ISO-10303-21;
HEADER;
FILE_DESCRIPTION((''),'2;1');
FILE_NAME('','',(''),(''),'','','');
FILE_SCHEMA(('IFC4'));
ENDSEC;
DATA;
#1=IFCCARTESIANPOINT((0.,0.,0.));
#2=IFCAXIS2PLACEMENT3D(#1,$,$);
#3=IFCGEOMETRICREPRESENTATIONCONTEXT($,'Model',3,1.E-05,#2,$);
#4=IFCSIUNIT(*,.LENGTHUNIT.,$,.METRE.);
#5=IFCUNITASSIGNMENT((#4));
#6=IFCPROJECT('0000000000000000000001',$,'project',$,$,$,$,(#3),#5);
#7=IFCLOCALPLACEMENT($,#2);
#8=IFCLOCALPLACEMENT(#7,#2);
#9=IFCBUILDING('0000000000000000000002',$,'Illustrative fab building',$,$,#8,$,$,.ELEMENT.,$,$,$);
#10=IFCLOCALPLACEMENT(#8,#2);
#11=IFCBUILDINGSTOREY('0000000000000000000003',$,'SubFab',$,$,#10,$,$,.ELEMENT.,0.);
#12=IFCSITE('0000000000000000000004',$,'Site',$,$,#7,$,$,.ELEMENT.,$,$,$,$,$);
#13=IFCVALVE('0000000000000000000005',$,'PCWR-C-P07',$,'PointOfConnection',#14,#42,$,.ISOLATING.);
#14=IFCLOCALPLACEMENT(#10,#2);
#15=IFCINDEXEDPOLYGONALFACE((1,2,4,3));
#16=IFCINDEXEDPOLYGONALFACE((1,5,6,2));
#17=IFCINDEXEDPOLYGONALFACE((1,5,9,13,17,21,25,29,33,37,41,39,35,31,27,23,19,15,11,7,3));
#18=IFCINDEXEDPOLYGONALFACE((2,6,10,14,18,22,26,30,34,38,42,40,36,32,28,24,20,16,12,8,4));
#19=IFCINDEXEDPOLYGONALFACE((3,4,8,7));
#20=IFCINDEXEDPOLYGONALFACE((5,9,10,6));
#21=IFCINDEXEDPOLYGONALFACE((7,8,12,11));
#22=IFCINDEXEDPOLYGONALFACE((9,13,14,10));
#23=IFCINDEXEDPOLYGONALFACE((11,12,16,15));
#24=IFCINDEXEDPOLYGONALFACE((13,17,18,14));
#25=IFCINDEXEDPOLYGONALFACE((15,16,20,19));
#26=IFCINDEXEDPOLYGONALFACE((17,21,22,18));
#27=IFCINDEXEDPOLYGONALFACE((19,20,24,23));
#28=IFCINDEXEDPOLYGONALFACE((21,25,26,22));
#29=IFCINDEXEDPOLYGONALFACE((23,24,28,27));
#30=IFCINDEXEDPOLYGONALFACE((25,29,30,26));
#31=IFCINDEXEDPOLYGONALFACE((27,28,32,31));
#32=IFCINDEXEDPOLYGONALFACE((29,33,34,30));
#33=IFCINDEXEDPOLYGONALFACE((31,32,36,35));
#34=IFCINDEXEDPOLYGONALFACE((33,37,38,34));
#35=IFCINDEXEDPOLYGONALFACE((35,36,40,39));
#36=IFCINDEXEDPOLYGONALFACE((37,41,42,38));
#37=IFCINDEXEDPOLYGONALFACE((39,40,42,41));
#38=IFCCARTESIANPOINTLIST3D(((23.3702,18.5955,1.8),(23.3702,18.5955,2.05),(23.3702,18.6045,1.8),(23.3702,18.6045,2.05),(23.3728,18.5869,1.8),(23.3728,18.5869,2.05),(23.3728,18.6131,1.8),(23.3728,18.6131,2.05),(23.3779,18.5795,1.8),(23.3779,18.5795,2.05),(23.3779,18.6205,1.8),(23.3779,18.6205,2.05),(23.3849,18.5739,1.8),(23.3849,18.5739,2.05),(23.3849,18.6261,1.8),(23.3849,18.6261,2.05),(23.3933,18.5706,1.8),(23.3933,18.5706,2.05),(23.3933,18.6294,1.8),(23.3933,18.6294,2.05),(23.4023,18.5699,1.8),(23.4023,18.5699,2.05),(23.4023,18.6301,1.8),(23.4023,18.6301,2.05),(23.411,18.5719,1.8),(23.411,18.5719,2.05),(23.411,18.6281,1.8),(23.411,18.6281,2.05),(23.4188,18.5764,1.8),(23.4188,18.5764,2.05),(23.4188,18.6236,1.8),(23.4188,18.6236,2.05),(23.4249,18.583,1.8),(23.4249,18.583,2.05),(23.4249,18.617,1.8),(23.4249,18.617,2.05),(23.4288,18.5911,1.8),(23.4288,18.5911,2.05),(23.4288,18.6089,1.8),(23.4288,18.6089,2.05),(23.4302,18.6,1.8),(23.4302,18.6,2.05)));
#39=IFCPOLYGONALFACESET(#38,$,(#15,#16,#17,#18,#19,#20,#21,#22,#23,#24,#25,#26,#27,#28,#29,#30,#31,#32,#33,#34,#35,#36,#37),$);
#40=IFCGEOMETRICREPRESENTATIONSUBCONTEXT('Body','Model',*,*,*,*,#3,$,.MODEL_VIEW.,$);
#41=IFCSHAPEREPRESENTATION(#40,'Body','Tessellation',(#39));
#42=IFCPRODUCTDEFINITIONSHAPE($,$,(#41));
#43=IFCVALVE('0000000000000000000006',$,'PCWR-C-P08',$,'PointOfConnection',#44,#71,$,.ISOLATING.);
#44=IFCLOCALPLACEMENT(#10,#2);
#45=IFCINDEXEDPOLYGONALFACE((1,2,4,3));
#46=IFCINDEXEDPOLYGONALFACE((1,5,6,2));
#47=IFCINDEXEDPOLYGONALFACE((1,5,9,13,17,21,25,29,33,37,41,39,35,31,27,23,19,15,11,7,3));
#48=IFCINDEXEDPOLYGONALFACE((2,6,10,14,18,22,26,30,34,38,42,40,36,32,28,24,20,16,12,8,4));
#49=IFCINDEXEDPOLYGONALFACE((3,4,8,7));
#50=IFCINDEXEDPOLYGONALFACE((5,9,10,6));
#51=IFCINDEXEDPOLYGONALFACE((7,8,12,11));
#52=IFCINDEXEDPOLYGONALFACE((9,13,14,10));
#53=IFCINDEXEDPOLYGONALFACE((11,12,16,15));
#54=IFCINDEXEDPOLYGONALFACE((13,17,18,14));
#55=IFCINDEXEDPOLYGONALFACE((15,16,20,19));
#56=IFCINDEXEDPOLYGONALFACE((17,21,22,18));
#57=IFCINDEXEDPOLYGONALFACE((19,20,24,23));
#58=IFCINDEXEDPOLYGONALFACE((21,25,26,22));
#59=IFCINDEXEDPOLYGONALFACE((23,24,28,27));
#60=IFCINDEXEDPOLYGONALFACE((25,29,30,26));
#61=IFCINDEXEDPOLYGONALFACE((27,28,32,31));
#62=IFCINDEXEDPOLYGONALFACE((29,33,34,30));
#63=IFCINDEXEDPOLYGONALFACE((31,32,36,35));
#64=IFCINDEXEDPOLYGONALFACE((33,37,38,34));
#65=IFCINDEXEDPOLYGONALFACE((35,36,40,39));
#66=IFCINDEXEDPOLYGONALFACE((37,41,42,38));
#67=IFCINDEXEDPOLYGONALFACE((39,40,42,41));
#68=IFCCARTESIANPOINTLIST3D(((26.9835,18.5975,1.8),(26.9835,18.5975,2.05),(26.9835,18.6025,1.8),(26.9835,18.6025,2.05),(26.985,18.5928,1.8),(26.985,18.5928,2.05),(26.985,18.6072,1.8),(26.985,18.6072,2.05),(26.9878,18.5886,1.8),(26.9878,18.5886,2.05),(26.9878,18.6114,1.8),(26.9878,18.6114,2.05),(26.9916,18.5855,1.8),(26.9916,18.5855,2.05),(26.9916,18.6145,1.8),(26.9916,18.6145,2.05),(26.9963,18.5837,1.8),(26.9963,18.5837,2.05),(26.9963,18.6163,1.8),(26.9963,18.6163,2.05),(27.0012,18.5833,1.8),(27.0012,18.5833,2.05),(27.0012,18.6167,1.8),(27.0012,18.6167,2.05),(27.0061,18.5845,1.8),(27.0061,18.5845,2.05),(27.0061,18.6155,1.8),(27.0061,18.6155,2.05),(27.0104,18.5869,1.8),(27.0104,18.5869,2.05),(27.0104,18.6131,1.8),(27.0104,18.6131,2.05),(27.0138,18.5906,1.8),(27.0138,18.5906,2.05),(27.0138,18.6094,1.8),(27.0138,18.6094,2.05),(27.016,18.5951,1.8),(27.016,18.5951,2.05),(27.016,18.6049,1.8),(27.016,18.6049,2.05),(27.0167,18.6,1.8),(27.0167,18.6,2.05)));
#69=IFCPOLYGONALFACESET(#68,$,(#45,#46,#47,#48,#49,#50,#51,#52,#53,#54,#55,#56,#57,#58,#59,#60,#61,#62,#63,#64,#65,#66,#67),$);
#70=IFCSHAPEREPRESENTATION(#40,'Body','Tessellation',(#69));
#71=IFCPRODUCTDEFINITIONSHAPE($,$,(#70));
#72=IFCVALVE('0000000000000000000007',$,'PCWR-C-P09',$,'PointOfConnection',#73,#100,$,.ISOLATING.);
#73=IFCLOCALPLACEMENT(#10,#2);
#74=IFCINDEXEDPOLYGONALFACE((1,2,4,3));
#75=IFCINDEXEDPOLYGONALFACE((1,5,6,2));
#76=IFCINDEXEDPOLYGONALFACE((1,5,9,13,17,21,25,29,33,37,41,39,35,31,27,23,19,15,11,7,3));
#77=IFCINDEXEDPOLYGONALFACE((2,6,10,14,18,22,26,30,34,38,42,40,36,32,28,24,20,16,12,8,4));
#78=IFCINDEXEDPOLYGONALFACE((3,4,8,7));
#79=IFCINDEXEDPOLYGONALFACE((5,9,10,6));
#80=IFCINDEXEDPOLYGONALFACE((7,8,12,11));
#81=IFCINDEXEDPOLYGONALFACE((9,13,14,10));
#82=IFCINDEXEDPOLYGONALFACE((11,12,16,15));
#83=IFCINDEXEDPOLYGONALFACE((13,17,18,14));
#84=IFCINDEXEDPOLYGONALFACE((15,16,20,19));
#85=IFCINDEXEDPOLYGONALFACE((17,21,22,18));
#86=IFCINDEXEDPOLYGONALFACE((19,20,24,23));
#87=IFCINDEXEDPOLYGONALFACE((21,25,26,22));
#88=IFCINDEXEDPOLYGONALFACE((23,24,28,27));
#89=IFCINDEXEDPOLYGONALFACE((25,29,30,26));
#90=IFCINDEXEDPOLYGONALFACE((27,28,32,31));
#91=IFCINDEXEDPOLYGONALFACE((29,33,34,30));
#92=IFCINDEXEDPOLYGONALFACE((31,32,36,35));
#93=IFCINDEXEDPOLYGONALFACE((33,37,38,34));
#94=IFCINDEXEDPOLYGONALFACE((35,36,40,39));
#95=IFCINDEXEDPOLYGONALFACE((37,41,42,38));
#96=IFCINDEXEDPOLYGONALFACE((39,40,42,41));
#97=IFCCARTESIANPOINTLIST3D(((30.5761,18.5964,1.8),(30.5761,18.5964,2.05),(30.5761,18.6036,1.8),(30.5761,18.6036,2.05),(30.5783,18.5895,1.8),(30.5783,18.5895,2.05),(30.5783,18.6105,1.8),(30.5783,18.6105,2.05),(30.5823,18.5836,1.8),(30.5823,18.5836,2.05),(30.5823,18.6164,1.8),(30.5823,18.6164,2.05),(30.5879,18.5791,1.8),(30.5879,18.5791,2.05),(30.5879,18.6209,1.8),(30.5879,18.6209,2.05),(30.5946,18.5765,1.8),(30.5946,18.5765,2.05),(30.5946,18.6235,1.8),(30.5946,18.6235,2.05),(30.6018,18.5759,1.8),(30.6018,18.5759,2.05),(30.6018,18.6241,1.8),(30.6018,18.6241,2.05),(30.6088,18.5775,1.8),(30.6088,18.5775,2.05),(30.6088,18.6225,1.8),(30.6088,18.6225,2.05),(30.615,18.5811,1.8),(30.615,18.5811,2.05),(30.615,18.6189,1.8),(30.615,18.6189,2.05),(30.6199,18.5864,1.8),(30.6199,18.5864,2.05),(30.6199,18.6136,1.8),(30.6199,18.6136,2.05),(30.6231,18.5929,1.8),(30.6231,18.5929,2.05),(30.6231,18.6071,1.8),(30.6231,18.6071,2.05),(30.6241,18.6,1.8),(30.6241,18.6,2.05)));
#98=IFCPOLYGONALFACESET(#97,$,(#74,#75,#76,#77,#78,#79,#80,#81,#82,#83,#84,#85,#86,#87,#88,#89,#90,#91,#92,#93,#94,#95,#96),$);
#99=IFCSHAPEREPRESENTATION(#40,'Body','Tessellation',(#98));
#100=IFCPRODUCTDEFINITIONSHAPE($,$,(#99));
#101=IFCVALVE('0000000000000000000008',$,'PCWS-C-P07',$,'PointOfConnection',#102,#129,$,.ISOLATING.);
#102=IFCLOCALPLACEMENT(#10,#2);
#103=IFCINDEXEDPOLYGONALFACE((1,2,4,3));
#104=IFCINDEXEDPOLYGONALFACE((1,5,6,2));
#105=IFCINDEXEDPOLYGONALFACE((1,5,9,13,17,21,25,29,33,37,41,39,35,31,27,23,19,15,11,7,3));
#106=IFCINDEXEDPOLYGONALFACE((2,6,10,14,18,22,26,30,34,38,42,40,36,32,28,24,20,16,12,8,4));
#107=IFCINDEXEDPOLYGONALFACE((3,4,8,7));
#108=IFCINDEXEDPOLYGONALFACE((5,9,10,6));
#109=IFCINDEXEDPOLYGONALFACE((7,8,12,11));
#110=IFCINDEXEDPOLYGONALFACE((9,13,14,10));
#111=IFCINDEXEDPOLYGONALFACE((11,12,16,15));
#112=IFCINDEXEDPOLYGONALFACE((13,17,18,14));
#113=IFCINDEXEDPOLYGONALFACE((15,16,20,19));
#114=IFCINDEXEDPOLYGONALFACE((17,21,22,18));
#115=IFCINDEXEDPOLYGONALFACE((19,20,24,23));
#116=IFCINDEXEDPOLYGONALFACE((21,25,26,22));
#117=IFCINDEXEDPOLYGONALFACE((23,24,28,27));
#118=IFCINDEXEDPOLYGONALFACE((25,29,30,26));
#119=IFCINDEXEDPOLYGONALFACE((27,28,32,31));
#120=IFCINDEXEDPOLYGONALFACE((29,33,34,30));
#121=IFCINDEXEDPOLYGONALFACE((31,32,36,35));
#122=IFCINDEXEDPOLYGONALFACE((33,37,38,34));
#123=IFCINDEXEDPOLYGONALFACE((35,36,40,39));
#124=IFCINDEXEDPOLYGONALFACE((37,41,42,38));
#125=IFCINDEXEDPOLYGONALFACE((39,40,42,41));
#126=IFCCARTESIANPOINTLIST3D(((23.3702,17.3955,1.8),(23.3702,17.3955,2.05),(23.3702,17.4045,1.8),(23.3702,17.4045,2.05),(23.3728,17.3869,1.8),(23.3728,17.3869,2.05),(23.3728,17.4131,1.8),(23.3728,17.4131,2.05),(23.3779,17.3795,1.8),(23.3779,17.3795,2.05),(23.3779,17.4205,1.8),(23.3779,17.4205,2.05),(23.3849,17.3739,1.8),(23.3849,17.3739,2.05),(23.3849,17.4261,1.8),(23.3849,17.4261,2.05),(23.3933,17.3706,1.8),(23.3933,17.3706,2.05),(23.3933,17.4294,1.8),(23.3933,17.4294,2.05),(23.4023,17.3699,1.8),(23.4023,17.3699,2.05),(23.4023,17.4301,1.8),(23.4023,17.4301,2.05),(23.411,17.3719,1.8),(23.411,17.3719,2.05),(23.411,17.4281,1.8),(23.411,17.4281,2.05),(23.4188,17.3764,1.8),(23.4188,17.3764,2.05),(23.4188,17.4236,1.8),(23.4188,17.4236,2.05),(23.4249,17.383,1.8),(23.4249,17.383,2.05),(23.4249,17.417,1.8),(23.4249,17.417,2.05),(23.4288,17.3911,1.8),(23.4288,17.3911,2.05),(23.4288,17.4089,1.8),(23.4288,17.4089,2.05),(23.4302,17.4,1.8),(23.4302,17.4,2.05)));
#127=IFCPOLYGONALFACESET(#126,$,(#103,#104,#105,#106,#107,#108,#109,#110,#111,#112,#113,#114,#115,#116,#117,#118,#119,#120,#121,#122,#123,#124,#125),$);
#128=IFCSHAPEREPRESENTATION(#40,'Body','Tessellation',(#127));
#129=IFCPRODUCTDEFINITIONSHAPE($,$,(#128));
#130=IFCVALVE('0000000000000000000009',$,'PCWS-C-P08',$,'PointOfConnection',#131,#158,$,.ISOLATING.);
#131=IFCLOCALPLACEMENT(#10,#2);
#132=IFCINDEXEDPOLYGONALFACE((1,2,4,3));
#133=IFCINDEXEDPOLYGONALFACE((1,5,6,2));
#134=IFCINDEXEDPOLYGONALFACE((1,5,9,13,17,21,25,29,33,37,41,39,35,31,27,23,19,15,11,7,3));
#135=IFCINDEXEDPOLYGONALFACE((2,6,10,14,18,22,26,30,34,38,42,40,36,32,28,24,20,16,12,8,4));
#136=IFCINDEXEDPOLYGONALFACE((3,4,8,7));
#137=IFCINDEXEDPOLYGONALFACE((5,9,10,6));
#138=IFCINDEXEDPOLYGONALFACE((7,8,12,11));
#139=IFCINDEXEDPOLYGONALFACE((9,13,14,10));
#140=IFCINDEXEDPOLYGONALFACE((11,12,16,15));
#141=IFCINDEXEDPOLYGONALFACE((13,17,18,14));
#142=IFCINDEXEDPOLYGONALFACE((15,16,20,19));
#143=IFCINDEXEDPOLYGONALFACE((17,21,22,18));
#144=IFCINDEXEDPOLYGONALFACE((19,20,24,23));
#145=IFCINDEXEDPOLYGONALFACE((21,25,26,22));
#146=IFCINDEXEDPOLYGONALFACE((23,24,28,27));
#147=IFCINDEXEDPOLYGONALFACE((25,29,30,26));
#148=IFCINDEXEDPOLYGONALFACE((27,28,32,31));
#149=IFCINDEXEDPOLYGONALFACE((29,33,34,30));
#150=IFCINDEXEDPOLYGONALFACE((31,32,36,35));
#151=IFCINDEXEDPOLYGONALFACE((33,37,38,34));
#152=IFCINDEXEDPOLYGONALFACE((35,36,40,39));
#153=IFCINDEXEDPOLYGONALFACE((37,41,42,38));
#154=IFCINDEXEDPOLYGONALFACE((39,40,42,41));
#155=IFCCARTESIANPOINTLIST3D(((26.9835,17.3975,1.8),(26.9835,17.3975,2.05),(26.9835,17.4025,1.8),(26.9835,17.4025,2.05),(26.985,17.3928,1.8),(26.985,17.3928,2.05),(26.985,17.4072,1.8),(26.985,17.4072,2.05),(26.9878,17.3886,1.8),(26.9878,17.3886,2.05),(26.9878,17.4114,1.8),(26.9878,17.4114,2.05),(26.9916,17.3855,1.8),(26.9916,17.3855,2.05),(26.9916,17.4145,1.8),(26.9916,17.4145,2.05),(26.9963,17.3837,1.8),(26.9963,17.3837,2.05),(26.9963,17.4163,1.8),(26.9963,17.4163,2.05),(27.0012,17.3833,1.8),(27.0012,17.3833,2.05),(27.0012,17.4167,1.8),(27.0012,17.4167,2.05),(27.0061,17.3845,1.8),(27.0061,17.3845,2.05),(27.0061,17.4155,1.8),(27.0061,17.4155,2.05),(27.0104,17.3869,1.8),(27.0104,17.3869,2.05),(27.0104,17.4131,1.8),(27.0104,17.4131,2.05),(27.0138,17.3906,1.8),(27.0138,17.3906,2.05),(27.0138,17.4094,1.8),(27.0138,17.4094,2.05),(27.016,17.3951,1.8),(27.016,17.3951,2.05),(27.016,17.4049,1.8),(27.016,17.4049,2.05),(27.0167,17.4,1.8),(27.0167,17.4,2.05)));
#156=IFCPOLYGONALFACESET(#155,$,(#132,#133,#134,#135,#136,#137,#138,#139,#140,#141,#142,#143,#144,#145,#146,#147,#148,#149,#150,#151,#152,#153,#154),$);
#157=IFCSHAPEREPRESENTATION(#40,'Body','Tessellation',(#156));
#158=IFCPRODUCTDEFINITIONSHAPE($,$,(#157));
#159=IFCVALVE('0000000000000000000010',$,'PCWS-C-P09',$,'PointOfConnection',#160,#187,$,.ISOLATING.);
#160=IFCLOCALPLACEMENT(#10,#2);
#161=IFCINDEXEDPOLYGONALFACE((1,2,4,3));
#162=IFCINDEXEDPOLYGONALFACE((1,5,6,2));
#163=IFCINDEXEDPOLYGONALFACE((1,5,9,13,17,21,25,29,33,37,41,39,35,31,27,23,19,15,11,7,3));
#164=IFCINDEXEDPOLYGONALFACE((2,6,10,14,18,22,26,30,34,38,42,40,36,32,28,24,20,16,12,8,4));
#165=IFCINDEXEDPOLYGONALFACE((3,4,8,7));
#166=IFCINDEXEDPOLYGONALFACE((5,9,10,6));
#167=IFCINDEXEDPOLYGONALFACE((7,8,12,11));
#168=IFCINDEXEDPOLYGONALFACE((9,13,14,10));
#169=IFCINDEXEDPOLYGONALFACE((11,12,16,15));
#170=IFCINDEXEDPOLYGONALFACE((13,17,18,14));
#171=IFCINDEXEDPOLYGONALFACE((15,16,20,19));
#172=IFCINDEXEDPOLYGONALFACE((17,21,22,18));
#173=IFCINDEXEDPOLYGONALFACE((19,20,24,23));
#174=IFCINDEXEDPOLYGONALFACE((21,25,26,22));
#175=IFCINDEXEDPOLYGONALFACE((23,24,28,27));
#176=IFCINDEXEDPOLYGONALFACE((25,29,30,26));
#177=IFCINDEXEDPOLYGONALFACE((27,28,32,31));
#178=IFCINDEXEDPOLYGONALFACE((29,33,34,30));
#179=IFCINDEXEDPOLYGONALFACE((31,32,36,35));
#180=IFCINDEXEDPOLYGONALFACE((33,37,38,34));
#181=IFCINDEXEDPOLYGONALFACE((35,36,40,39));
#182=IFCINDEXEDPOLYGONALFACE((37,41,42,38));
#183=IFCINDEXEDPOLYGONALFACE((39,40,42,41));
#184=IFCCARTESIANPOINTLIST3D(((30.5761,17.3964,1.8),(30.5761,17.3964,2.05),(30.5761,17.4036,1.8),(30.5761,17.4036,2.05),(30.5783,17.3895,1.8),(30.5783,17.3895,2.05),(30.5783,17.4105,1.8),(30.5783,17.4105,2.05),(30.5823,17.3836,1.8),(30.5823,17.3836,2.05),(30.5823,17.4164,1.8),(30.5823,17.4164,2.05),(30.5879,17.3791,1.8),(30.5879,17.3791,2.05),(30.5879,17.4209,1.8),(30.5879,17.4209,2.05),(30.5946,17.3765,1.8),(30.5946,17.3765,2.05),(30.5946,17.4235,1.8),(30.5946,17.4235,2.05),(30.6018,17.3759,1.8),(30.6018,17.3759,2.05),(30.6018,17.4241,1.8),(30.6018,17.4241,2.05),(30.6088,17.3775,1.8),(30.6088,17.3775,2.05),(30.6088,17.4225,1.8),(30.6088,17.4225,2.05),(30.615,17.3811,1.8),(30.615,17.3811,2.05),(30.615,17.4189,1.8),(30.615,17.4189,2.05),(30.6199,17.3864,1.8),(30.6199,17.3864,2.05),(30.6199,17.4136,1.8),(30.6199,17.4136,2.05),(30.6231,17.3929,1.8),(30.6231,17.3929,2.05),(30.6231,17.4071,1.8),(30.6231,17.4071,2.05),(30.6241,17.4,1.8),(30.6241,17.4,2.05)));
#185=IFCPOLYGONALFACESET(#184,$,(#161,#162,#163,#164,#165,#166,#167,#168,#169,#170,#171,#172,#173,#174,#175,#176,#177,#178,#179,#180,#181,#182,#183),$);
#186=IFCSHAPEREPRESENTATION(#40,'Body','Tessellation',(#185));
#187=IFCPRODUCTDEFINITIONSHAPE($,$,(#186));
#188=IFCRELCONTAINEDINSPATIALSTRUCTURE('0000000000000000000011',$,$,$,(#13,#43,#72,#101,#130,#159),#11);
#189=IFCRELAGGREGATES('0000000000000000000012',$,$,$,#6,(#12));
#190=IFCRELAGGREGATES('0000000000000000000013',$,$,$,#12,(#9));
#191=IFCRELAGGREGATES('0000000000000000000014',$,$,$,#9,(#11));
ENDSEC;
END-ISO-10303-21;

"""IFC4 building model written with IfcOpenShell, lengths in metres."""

from ifc_helpers import new_model, entity, si_unit, frame, origin, place, context, subcontext, project, spatial, element, save


model = new_model("IFC4")

# Units and contexts
model_context = context("Model", 3, precision=1e-05, world=origin())
body_context = subcontext(model_context, "Body", "Model", "MODEL_VIEW")
ifc_project = project(units=[si_unit("LENGTHUNIT", "METRE")], contexts=[model_context])

# Site, building, storey
site_placement = place(None, origin())
site = spatial("IfcSite", under=ifc_project, at=site_placement, Name="Site", CompositionType="ELEMENT")
building_placement = place(site_placement, origin())
building = spatial("IfcBuilding", under=site, at=building_placement, Name="Illustrative fab building", CompositionType="ELEMENT")
storey_placement = place(building_placement, origin())
storey = spatial("IfcBuildingStorey", under=building, at=storey_placement, Name="SubFab", CompositionType="ELEMENT", Elevation=0.0)

# Valves
valve_1_placement = place(storey_placement, frame((23.4, 18.6, 1.8)))
element("IfcValve", 1, at=valve_1_placement, inside=storey, Name="PCWR-C-P07", ObjectType="PointOfConnection", PredefinedType="ISOLATING", context=body_context, shape_type="AdvancedSweptSolid", body=[
    entity("IfcSweptDiskSolid", entity("IfcPolyline", [entity("IfcCartesianPoint", [0.0, 0.0, 0.0]), entity("IfcCartesianPoint", [0.0, 0.0, 0.25])]), 0.0302),
])
valve_2_placement = place(storey_placement, frame((27.0, 18.6, 1.8)))
element("IfcValve", 2, at=valve_2_placement, inside=storey, Name="PCWR-C-P08", ObjectType="PointOfConnection", PredefinedType="ISOLATING", context=body_context, shape_type="AdvancedSweptSolid", body=[
    entity("IfcSweptDiskSolid", entity("IfcPolyline", [entity("IfcCartesianPoint", [0.0, 0.0, 0.0]), entity("IfcCartesianPoint", [0.0, 0.0, 0.25])]), 0.0167),
])
valve_3_placement = place(storey_placement, frame((30.6, 18.6, 1.8)))
element("IfcValve", 3, at=valve_3_placement, inside=storey, Name="PCWR-C-P09", ObjectType="PointOfConnection", PredefinedType="ISOLATING", context=body_context, shape_type="AdvancedSweptSolid", body=[
    entity("IfcSweptDiskSolid", entity("IfcPolyline", [entity("IfcCartesianPoint", [0.0, 0.0, 0.0]), entity("IfcCartesianPoint", [0.0, 0.0, 0.25])]), 0.0241),
])
valve_4_placement = place(storey_placement, frame((23.4, 17.4, 1.8)))
element("IfcValve", 4, at=valve_4_placement, inside=storey, Name="PCWS-C-P07", ObjectType="PointOfConnection", PredefinedType="ISOLATING", context=body_context, shape_type="AdvancedSweptSolid", body=[
    entity("IfcSweptDiskSolid", entity("IfcPolyline", [entity("IfcCartesianPoint", [0.0, 0.0, 0.0]), entity("IfcCartesianPoint", [0.0, 0.0, 0.25])]), 0.0302),
])
valve_5_placement = place(storey_placement, frame((27.0, 17.4, 1.8)))
element("IfcValve", 5, at=valve_5_placement, inside=storey, Name="PCWS-C-P08", ObjectType="PointOfConnection", PredefinedType="ISOLATING", context=body_context, shape_type="AdvancedSweptSolid", body=[
    entity("IfcSweptDiskSolid", entity("IfcPolyline", [entity("IfcCartesianPoint", [0.0, 0.0, 0.0]), entity("IfcCartesianPoint", [0.0, 0.0, 0.25])]), 0.0167),
])
valve_6_placement = place(storey_placement, frame((30.6, 17.4, 1.8)))
element("IfcValve", 6, at=valve_6_placement, inside=storey, Name="PCWS-C-P09", ObjectType="PointOfConnection", PredefinedType="ISOLATING", context=body_context, shape_type="AdvancedSweptSolid", body=[
    entity("IfcSweptDiskSolid", entity("IfcPolyline", [entity("IfcCartesianPoint", [0.0, 0.0, 0.0]), entity("IfcCartesianPoint", [0.0, 0.0, 0.25])]), 0.0241),
])

save(model, "model.ifc")
